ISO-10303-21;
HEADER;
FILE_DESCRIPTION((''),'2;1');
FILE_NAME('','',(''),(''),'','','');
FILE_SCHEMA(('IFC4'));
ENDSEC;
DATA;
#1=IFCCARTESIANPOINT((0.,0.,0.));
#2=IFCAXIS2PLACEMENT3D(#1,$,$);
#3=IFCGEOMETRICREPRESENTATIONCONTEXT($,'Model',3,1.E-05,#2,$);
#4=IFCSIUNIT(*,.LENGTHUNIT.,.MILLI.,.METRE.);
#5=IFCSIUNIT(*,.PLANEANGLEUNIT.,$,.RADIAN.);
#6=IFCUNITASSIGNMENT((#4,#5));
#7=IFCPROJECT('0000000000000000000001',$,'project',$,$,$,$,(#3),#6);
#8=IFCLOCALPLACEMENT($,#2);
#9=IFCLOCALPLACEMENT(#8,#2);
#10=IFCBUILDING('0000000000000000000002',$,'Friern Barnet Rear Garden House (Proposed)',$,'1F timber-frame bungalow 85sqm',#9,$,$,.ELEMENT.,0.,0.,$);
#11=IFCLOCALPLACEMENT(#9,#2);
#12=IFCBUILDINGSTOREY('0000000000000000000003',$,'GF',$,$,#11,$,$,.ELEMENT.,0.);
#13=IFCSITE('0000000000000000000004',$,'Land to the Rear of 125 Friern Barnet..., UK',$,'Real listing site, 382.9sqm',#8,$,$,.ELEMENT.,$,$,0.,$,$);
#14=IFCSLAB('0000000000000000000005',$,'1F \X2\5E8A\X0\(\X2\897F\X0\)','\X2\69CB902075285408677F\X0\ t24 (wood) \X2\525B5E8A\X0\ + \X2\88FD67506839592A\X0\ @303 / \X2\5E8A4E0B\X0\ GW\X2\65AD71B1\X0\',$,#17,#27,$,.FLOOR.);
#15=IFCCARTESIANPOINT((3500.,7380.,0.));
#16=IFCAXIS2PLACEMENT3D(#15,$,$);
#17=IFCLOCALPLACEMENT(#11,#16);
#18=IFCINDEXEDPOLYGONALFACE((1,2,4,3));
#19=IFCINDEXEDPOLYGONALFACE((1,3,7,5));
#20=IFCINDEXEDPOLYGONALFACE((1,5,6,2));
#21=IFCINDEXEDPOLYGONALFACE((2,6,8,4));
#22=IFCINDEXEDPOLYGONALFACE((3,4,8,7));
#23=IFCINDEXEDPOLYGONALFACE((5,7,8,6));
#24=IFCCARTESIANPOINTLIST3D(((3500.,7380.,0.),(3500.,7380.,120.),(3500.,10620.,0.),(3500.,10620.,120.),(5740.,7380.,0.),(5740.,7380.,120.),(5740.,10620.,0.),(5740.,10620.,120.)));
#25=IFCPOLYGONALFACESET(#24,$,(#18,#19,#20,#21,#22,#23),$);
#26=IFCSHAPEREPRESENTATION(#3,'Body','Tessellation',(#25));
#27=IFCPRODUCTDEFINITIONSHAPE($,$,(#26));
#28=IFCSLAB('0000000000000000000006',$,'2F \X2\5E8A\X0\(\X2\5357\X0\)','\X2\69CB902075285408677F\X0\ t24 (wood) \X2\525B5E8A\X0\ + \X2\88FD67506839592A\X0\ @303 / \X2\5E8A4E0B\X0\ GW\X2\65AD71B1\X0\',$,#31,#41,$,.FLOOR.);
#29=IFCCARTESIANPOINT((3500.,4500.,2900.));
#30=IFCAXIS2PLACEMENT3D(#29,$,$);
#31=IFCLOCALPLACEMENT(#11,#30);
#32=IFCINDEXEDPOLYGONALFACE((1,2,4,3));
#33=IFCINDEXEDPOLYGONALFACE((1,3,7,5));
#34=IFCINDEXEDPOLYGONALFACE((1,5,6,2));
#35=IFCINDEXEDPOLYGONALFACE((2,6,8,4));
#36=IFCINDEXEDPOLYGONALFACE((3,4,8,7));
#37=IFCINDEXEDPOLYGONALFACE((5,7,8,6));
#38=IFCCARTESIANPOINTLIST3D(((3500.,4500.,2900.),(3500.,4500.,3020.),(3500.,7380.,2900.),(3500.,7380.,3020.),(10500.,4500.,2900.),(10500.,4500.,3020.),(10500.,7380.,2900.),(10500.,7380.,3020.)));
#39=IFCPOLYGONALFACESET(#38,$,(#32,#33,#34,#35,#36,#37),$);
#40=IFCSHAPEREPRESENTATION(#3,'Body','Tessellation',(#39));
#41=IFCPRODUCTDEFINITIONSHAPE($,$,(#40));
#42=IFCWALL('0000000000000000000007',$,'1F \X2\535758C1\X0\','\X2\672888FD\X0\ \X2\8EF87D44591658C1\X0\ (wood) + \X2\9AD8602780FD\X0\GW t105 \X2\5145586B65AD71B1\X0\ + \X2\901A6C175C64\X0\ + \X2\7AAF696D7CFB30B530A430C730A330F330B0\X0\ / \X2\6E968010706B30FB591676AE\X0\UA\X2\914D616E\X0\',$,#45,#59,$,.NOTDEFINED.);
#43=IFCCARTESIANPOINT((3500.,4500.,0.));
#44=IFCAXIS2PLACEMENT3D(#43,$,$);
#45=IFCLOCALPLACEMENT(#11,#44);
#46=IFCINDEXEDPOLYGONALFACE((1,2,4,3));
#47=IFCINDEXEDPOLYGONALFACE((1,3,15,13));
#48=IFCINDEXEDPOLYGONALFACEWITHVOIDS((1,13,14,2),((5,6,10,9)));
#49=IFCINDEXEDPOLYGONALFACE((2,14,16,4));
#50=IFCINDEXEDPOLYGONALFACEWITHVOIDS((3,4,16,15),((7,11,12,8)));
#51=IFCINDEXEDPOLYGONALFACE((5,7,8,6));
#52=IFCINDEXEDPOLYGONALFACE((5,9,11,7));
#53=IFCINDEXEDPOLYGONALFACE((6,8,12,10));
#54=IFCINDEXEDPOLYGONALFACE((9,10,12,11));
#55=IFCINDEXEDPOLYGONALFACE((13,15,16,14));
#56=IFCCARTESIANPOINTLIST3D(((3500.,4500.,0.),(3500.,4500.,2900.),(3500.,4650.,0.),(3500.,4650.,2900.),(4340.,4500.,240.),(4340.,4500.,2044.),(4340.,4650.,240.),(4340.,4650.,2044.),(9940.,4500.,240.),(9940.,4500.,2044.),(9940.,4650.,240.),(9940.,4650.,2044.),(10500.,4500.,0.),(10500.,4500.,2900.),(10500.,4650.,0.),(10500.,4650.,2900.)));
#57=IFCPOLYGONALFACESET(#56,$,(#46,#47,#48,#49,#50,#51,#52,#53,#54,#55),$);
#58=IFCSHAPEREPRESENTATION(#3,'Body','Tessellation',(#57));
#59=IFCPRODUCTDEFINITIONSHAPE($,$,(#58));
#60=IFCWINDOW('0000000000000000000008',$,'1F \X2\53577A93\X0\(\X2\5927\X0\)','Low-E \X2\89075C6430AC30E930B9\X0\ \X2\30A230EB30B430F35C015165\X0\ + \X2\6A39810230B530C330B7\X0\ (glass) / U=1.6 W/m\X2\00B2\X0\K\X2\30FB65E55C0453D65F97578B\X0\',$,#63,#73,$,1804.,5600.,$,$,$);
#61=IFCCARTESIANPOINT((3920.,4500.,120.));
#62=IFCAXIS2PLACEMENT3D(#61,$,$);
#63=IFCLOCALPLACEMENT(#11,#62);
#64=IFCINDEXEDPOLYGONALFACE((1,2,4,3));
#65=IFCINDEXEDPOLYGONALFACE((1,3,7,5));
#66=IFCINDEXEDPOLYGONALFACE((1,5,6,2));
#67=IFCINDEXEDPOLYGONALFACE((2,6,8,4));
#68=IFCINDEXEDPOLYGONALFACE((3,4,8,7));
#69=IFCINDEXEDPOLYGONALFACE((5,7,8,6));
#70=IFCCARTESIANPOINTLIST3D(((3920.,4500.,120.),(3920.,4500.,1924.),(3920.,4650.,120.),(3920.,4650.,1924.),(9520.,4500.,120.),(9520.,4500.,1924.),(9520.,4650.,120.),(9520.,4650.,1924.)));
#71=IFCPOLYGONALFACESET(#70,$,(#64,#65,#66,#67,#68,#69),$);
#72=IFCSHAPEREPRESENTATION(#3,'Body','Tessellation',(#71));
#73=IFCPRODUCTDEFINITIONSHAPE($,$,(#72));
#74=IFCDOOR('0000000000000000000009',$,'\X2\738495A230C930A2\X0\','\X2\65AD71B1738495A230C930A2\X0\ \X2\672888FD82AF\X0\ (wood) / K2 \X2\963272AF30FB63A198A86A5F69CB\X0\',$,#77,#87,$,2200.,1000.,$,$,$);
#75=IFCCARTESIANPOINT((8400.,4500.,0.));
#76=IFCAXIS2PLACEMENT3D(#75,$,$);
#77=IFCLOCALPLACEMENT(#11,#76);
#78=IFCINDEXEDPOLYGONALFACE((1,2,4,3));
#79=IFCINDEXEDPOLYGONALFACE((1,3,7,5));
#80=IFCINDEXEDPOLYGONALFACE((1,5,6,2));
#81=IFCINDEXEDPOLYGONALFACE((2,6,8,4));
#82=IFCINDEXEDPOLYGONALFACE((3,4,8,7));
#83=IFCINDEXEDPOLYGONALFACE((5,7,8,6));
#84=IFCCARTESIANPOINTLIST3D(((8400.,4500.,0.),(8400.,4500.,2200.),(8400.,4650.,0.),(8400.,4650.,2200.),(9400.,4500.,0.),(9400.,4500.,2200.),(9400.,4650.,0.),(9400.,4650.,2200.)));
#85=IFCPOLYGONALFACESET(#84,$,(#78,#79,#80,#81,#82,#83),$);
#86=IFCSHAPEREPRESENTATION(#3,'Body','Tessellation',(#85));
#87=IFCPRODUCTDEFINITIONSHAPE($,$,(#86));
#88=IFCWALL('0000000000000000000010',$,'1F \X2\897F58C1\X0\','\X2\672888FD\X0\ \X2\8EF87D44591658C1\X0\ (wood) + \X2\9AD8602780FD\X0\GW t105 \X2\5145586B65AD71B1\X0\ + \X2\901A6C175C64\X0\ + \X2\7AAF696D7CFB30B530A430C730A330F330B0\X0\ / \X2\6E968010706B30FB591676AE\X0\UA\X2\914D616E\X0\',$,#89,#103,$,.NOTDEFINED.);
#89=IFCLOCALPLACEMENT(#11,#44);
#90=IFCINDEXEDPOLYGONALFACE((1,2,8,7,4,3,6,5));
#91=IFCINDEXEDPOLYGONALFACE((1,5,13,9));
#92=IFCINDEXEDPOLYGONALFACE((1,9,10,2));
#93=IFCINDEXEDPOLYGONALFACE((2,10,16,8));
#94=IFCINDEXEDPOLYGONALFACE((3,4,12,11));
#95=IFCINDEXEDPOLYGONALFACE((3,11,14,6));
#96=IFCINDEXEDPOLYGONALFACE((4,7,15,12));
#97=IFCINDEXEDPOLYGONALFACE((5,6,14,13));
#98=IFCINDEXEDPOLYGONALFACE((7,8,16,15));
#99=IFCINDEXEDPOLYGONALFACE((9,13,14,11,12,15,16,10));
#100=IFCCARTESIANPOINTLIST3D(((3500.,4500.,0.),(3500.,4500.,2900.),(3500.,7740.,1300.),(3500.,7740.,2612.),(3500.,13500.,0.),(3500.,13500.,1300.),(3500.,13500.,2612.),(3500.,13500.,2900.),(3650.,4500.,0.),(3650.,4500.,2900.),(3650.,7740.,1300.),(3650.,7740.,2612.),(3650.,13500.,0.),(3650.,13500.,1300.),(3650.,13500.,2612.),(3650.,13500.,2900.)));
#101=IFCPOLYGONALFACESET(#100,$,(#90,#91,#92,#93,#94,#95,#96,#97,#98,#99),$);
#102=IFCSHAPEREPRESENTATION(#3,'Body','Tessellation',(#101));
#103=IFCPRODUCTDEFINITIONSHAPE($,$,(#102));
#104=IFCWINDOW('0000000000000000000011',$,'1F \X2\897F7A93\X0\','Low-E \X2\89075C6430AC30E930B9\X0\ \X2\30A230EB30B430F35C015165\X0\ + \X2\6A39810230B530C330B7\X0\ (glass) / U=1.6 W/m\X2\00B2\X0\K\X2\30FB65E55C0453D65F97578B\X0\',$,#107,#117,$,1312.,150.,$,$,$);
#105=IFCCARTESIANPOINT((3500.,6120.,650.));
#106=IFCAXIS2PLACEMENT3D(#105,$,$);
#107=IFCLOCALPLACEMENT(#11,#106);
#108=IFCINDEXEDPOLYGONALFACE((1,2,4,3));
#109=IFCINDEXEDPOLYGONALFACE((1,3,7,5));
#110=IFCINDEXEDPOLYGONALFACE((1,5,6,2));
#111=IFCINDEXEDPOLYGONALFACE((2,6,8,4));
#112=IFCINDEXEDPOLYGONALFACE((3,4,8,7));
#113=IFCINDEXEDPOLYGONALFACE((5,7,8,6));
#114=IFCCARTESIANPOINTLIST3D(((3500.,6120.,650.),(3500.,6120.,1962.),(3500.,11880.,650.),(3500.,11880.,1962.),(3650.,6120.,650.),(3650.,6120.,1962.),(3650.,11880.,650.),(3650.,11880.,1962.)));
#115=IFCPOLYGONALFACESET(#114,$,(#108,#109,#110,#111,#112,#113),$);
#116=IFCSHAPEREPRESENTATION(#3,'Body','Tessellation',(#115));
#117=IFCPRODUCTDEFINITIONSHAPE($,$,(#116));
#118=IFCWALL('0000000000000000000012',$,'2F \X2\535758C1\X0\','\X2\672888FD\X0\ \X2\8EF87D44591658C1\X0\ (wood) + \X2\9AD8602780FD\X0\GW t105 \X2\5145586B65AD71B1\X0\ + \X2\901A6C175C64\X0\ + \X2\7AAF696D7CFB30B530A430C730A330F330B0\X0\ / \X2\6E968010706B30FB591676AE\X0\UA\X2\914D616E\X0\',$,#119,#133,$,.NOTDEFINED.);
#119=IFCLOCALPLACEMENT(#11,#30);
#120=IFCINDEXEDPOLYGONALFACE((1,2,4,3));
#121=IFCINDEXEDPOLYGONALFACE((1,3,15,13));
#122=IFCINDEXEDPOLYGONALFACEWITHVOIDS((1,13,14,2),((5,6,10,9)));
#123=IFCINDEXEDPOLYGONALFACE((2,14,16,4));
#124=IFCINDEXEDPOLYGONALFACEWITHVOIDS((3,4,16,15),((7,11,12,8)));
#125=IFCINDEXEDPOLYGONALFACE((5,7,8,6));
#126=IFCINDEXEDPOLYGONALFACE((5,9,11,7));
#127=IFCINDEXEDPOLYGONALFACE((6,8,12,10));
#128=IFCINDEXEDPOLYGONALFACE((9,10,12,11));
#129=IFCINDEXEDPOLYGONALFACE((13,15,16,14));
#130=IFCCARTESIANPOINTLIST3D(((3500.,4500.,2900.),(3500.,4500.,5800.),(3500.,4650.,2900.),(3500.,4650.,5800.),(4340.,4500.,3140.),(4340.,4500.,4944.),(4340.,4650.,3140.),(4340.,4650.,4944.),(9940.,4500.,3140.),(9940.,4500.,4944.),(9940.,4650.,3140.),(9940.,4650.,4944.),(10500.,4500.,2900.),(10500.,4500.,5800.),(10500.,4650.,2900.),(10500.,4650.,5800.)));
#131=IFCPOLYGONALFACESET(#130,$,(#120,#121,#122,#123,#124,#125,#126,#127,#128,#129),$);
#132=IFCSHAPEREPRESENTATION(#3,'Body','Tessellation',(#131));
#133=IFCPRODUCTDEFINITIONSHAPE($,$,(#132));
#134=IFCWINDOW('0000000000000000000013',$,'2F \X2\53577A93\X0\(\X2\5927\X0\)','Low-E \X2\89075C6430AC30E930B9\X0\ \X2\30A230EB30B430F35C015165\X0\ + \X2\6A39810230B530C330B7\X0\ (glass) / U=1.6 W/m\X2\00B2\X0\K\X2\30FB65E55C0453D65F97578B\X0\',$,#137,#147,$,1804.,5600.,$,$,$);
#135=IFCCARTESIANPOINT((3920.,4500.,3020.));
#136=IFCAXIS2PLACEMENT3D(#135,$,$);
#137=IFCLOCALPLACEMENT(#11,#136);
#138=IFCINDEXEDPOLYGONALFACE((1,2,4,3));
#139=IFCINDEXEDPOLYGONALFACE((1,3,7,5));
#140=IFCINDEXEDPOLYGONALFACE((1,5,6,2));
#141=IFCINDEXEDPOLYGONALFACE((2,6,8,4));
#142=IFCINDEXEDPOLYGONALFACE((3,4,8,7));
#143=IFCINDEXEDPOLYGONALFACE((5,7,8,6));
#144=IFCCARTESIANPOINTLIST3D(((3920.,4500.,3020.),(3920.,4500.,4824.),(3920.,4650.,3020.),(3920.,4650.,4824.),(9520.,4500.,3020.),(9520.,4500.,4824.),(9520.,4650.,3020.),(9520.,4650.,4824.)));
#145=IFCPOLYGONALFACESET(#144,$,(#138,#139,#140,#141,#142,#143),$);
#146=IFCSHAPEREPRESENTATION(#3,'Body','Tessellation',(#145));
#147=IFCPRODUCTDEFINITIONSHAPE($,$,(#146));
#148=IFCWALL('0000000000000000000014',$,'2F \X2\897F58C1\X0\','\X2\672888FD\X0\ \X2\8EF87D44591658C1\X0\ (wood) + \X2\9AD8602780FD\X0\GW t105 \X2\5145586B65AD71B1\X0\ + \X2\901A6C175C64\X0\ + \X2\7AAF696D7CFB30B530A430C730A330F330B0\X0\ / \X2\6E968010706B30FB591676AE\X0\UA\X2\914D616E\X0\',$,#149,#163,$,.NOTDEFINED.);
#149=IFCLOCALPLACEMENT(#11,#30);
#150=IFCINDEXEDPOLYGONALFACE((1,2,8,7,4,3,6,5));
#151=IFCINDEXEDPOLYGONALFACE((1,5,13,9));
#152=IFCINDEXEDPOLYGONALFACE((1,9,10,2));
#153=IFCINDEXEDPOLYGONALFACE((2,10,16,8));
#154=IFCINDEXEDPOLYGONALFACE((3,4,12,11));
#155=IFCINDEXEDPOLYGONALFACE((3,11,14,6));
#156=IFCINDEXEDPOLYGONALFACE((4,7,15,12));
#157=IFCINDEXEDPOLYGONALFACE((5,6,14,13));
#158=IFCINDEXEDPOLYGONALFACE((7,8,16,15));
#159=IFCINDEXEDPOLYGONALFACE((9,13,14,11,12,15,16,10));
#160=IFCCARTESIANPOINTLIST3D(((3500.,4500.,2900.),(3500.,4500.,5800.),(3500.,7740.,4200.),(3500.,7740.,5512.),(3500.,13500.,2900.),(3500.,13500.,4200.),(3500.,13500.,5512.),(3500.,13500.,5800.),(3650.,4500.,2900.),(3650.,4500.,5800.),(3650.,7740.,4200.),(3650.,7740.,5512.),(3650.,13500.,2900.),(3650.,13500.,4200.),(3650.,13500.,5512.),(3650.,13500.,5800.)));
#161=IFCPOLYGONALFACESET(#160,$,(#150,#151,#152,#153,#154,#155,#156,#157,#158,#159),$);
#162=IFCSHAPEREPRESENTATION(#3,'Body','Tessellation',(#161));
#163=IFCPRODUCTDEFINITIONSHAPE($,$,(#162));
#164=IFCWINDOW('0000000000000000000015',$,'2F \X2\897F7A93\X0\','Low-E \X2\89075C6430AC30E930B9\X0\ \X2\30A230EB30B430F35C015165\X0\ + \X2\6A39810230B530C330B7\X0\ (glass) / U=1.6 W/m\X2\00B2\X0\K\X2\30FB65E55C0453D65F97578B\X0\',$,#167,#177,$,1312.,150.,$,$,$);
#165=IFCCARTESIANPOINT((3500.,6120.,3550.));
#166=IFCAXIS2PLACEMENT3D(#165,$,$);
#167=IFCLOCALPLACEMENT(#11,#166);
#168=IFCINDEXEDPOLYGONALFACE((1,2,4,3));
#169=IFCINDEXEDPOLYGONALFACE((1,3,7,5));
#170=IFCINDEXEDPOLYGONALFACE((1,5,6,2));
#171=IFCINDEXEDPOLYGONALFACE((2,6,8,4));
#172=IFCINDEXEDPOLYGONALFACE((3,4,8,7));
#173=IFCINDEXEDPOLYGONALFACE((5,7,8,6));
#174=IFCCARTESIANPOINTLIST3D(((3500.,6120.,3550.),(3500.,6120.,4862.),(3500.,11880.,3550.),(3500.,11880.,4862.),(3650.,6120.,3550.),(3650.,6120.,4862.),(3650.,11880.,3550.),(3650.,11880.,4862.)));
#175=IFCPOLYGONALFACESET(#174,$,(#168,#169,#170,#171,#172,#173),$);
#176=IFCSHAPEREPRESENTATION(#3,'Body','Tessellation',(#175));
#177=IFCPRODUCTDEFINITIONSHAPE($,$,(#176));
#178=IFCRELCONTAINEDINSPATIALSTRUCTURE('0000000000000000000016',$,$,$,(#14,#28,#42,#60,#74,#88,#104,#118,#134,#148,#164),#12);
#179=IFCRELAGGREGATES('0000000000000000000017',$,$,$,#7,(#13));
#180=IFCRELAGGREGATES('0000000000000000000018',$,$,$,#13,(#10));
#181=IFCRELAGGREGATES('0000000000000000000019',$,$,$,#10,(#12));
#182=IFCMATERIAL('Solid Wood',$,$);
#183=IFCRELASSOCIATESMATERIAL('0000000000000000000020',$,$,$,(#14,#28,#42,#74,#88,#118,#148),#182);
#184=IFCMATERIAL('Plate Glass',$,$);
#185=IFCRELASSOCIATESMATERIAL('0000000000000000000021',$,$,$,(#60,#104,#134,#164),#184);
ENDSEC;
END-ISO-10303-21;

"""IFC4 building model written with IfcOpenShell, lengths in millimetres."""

from ifc_helpers import new_model, si_unit, frame, frame_2d, origin, place, context, project, spatial, rectangle, extrude, material, element, fill, save


model = new_model("IFC4")

# Units and contexts
model_context = context("Model", 3, precision=1e-05, world=origin())
ifc_project = project(units=[si_unit("LENGTHUNIT", "METRE", prefix="MILLI"), si_unit("PLANEANGLEUNIT", "RADIAN")], contexts=[model_context])

# Site, building, storey
site_placement = place(None, origin())
site = spatial("IfcSite", under=ifc_project, at=site_placement, Name="Land to the Rear of 125 Friern Barnet..., UK", ObjectType="Real listing site, 382.9sqm", CompositionType="ELEMENT", RefElevation=0.0)
building_placement = place(site_placement, origin())
building = spatial("IfcBuilding", under=site, at=building_placement, Name="Friern Barnet Rear Garden House (Proposed)", ObjectType="1F timber-frame bungalow 85sqm", CompositionType="ELEMENT", ElevationOfRefHeight=0.0, ElevationOfTerrain=0.0)
storey_placement = place(building_placement, origin())
storey = spatial("IfcBuildingStorey", under=building, at=storey_placement, Name="GF", CompositionType="ELEMENT", Elevation=0.0)

# Slabs
ifc_material_1 = material(Name="Solid Wood")
slab_1_placement = place(storey_placement, frame((3500.0, 7380.0, 0.0)))
element("IfcSlab", 1, at=slab_1_placement, inside=storey, material=ifc_material_1, Name="1F 床(西)", Description="構造用合板 t24 (wood) 剛床 + 製材根太 @303 / 床下 GW断熱", PredefinedType="FLOOR", context=model_context, shape_type="SweptSolid", body=[
    extrude(rectangle(XDim=2240.0, YDim=3240.0, at=frame_2d((1120.0, 1620.0))), frame((3500.0, 7380.0, 0.0)), (0.0, 0.0, 1.0), 120.0),
])
slab_2_placement = place(storey_placement, frame((3500.0, 4500.0, 2900.0)))
element("IfcSlab", 2, at=slab_2_placement, inside=storey, material=ifc_material_1, Name="2F 床(南)", Description="構造用合板 t24 (wood) 剛床 + 製材根太 @303 / 床下 GW断熱", PredefinedType="FLOOR", context=model_context, shape_type="SweptSolid", body=[
    extrude(rectangle(XDim=7000.0, YDim=2880.0, at=frame_2d((3500.0, 1440.0))), frame((3500.0, 4500.0, 2900.0)), (0.0, 0.0, 1.0), 120.0),
])

# Wall, openings, window, door
wall_1_placement = place(storey_placement, frame((3500.0, 4500.0, 0.0)))
wall_1 = element("IfcWall", 3, at=wall_1_placement, inside=storey, material=ifc_material_1, Name="1F 南壁", Description="木製 軸組外壁 (wood) + 高性能GW t105 充填断熱 + 通気層 + 窯業系サイディング / 準耐火・外皮UA配慮", PredefinedType="NOTDEFINED", context=model_context, shape_type="SweptSolid", body=[
    extrude(rectangle(XDim=7000.0, YDim=150.0, at=frame_2d((3500.0, 75.0))), frame((3500.0, 4500.0, 0.0)), (0.0, 0.0, 1.0), 2900.0),
])
opening_1_placement = place(storey_placement, frame((3920.0, 4500.0, 120.0)))
opening_1 = element("IfcOpeningElement", 4, at=opening_1_placement, cuts=wall_1, PredefinedType="NOTDEFINED", context=model_context, shape_type="SweptSolid", body=[
    extrude(rectangle(XDim=5600.0, YDim=150.0, at=frame_2d((2800.0, 75.0))), frame((3920.0, 4500.0, 120.0)), (0.0, 0.0, 1.0), 1804.0),
])
opening_2_placement = place(storey_placement, frame((8400.0, 4500.0, 0.0)))
opening_2 = element("IfcOpeningElement", 5, at=opening_2_placement, cuts=wall_1, PredefinedType="NOTDEFINED", context=model_context, shape_type="SweptSolid", body=[
    extrude(rectangle(XDim=1000.0, YDim=150.0, at=frame_2d((500.0, 75.0))), frame((8400.0, 4500.0, 0.0)), (0.0, 0.0, 1.0), 2200.0),
])
ifc_material_2 = material(Name="Plate Glass")
window_1_placement = place(storey_placement, frame((3920.0, 4500.0, 120.0)))
window_1 = element("IfcWindow", 6, at=window_1_placement, inside=storey, material=ifc_material_2, Name="1F 南窓(大)", Description="Low-E 複層ガラス アルゴン封入 + 樹脂サッシ (glass) / U=1.6 W/m²K・日射取得型", OverallHeight=1804.0, OverallWidth=5600.0, context=model_context, shape_type="SweptSolid", body=[
    extrude(rectangle(XDim=5600.0, YDim=150.0, at=frame_2d((2800.0, 75.0))), frame((3920.0, 4500.0, 120.0)), (0.0, 0.0, 1.0), 1804.0),
])
fill(opening_1, window_1)
door_placement = place(storey_placement, frame((8400.0, 4500.0, 0.0)))
door = element("IfcDoor", 7, at=door_placement, inside=storey, material=ifc_material_1, Name="玄関ドア", Description="断熱玄関ドア 木製芯 (wood) / K2 防犯・採風機構", OverallHeight=2200.0, OverallWidth=1000.0, context=model_context, shape_type="SweptSolid", body=[
    extrude(rectangle(XDim=1000.0, YDim=150.0, at=frame_2d((500.0, 75.0))), frame((8400.0, 4500.0, 0.0)), (0.0, 0.0, 1.0), 2200.0),
])
fill(opening_2, door)

# Walls, openings, windows
wall_2_placement = place(storey_placement, frame((3500.0, 4500.0, 0.0)))
wall_2 = element("IfcWall", 8, at=wall_2_placement, inside=storey, material=ifc_material_1, Name="1F 西壁", Description="木製 軸組外壁 (wood) + 高性能GW t105 充填断熱 + 通気層 + 窯業系サイディング / 準耐火・外皮UA配慮", PredefinedType="NOTDEFINED", context=model_context, shape_type="SweptSolid", body=[
    extrude(rectangle(XDim=150.0, YDim=9000.0, at=frame_2d((75.0, 4500.0))), frame((3500.0, 4500.0, 0.0)), (0.0, 0.0, 1.0), 2900.0),
])
opening_3_placement = place(storey_placement, frame((3500.0, 6120.0, 650.0)))
opening_3 = element("IfcOpeningElement", 9, at=opening_3_placement, cuts=wall_2, PredefinedType="NOTDEFINED", context=model_context, shape_type="SweptSolid", body=[
    extrude(rectangle(XDim=150.0, YDim=5760.0, at=frame_2d((75.0, 2880.0))), frame((3500.0, 6120.0, 650.0)), (0.0, 0.0, 1.0), 1312.0),
])
window_2_placement = place(storey_placement, frame((3500.0, 6120.0, 650.0)))
window_2 = element("IfcWindow", 10, at=window_2_placement, inside=storey, material=ifc_material_2, Name="1F 西窓", Description="Low-E 複層ガラス アルゴン封入 + 樹脂サッシ (glass) / U=1.6 W/m²K・日射取得型", OverallHeight=1312.0, OverallWidth=150.0, context=model_context, shape_type="SweptSolid", body=[
    extrude(rectangle(XDim=150.0, YDim=5760.0, at=frame_2d((75.0, 2880.0))), frame((3500.0, 6120.0, 650.0)), (0.0, 0.0, 1.0), 1312.0),
])
fill(opening_3, window_2)
wall_3_placement = place(storey_placement, frame((3500.0, 4500.0, 2900.0)))
wall_3 = element("IfcWall", 11, at=wall_3_placement, inside=storey, material=ifc_material_1, Name="2F 南壁", Description="木製 軸組外壁 (wood) + 高性能GW t105 充填断熱 + 通気層 + 窯業系サイディング / 準耐火・外皮UA配慮", PredefinedType="NOTDEFINED", context=model_context, shape_type="SweptSolid", body=[
    extrude(rectangle(XDim=7000.0, YDim=150.0, at=frame_2d((3500.0, 75.0))), frame((3500.0, 4500.0, 2900.0)), (0.0, 0.0, 1.0), 2900.0),
])
opening_4_placement = place(storey_placement, frame((3920.0, 4500.0, 3020.0)))
opening_4 = element("IfcOpeningElement", 12, at=opening_4_placement, cuts=wall_3, PredefinedType="NOTDEFINED", context=model_context, shape_type="SweptSolid", body=[
    extrude(rectangle(XDim=5600.0, YDim=150.0, at=frame_2d((2800.0, 75.0))), frame((3920.0, 4500.0, 3020.0)), (0.0, 0.0, 1.0), 1804.0),
])
window_3_placement = place(storey_placement, frame((3920.0, 4500.0, 3020.0)))
window_3 = element("IfcWindow", 13, at=window_3_placement, inside=storey, material=ifc_material_2, Name="2F 南窓(大)", Description="Low-E 複層ガラス アルゴン封入 + 樹脂サッシ (glass) / U=1.6 W/m²K・日射取得型", OverallHeight=1804.0, OverallWidth=5600.0, context=model_context, shape_type="SweptSolid", body=[
    extrude(rectangle(XDim=5600.0, YDim=150.0, at=frame_2d((2800.0, 75.0))), frame((3920.0, 4500.0, 3020.0)), (0.0, 0.0, 1.0), 1804.0),
])
fill(opening_4, window_3)
wall_4_placement = place(storey_placement, frame((3500.0, 4500.0, 2900.0)))
wall_4 = element("IfcWall", 14, at=wall_4_placement, inside=storey, material=ifc_material_1, Name="2F 西壁", Description="木製 軸組外壁 (wood) + 高性能GW t105 充填断熱 + 通気層 + 窯業系サイディング / 準耐火・外皮UA配慮", PredefinedType="NOTDEFINED", context=model_context, shape_type="SweptSolid", body=[
    extrude(rectangle(XDim=150.0, YDim=9000.0, at=frame_2d((75.0, 4500.0))), frame((3500.0, 4500.0, 2900.0)), (0.0, 0.0, 1.0), 2900.0),
])
opening_5_placement = place(storey_placement, frame((3500.0, 6120.0, 3550.0)))
opening_5 = element("IfcOpeningElement", 15, at=opening_5_placement, cuts=wall_4, PredefinedType="NOTDEFINED", context=model_context, shape_type="SweptSolid", body=[
    extrude(rectangle(XDim=150.0, YDim=5760.0, at=frame_2d((75.0, 2880.0))), frame((3500.0, 6120.0, 3550.0)), (0.0, 0.0, 1.0), 1312.0),
])
window_4_placement = place(storey_placement, frame((3500.0, 6120.0, 3550.0)))
window_4 = element("IfcWindow", 16, at=window_4_placement, inside=storey, material=ifc_material_2, Name="2F 西窓", Description="Low-E 複層ガラス アルゴン封入 + 樹脂サッシ (glass) / U=1.6 W/m²K・日射取得型", OverallHeight=1312.0, OverallWidth=150.0, context=model_context, shape_type="SweptSolid", body=[
    extrude(rectangle(XDim=150.0, YDim=5760.0, at=frame_2d((75.0, 2880.0))), frame((3500.0, 6120.0, 3550.0)), (0.0, 0.0, 1.0), 1312.0),
])
fill(opening_5, window_4)

save(model, "model.ifc")
